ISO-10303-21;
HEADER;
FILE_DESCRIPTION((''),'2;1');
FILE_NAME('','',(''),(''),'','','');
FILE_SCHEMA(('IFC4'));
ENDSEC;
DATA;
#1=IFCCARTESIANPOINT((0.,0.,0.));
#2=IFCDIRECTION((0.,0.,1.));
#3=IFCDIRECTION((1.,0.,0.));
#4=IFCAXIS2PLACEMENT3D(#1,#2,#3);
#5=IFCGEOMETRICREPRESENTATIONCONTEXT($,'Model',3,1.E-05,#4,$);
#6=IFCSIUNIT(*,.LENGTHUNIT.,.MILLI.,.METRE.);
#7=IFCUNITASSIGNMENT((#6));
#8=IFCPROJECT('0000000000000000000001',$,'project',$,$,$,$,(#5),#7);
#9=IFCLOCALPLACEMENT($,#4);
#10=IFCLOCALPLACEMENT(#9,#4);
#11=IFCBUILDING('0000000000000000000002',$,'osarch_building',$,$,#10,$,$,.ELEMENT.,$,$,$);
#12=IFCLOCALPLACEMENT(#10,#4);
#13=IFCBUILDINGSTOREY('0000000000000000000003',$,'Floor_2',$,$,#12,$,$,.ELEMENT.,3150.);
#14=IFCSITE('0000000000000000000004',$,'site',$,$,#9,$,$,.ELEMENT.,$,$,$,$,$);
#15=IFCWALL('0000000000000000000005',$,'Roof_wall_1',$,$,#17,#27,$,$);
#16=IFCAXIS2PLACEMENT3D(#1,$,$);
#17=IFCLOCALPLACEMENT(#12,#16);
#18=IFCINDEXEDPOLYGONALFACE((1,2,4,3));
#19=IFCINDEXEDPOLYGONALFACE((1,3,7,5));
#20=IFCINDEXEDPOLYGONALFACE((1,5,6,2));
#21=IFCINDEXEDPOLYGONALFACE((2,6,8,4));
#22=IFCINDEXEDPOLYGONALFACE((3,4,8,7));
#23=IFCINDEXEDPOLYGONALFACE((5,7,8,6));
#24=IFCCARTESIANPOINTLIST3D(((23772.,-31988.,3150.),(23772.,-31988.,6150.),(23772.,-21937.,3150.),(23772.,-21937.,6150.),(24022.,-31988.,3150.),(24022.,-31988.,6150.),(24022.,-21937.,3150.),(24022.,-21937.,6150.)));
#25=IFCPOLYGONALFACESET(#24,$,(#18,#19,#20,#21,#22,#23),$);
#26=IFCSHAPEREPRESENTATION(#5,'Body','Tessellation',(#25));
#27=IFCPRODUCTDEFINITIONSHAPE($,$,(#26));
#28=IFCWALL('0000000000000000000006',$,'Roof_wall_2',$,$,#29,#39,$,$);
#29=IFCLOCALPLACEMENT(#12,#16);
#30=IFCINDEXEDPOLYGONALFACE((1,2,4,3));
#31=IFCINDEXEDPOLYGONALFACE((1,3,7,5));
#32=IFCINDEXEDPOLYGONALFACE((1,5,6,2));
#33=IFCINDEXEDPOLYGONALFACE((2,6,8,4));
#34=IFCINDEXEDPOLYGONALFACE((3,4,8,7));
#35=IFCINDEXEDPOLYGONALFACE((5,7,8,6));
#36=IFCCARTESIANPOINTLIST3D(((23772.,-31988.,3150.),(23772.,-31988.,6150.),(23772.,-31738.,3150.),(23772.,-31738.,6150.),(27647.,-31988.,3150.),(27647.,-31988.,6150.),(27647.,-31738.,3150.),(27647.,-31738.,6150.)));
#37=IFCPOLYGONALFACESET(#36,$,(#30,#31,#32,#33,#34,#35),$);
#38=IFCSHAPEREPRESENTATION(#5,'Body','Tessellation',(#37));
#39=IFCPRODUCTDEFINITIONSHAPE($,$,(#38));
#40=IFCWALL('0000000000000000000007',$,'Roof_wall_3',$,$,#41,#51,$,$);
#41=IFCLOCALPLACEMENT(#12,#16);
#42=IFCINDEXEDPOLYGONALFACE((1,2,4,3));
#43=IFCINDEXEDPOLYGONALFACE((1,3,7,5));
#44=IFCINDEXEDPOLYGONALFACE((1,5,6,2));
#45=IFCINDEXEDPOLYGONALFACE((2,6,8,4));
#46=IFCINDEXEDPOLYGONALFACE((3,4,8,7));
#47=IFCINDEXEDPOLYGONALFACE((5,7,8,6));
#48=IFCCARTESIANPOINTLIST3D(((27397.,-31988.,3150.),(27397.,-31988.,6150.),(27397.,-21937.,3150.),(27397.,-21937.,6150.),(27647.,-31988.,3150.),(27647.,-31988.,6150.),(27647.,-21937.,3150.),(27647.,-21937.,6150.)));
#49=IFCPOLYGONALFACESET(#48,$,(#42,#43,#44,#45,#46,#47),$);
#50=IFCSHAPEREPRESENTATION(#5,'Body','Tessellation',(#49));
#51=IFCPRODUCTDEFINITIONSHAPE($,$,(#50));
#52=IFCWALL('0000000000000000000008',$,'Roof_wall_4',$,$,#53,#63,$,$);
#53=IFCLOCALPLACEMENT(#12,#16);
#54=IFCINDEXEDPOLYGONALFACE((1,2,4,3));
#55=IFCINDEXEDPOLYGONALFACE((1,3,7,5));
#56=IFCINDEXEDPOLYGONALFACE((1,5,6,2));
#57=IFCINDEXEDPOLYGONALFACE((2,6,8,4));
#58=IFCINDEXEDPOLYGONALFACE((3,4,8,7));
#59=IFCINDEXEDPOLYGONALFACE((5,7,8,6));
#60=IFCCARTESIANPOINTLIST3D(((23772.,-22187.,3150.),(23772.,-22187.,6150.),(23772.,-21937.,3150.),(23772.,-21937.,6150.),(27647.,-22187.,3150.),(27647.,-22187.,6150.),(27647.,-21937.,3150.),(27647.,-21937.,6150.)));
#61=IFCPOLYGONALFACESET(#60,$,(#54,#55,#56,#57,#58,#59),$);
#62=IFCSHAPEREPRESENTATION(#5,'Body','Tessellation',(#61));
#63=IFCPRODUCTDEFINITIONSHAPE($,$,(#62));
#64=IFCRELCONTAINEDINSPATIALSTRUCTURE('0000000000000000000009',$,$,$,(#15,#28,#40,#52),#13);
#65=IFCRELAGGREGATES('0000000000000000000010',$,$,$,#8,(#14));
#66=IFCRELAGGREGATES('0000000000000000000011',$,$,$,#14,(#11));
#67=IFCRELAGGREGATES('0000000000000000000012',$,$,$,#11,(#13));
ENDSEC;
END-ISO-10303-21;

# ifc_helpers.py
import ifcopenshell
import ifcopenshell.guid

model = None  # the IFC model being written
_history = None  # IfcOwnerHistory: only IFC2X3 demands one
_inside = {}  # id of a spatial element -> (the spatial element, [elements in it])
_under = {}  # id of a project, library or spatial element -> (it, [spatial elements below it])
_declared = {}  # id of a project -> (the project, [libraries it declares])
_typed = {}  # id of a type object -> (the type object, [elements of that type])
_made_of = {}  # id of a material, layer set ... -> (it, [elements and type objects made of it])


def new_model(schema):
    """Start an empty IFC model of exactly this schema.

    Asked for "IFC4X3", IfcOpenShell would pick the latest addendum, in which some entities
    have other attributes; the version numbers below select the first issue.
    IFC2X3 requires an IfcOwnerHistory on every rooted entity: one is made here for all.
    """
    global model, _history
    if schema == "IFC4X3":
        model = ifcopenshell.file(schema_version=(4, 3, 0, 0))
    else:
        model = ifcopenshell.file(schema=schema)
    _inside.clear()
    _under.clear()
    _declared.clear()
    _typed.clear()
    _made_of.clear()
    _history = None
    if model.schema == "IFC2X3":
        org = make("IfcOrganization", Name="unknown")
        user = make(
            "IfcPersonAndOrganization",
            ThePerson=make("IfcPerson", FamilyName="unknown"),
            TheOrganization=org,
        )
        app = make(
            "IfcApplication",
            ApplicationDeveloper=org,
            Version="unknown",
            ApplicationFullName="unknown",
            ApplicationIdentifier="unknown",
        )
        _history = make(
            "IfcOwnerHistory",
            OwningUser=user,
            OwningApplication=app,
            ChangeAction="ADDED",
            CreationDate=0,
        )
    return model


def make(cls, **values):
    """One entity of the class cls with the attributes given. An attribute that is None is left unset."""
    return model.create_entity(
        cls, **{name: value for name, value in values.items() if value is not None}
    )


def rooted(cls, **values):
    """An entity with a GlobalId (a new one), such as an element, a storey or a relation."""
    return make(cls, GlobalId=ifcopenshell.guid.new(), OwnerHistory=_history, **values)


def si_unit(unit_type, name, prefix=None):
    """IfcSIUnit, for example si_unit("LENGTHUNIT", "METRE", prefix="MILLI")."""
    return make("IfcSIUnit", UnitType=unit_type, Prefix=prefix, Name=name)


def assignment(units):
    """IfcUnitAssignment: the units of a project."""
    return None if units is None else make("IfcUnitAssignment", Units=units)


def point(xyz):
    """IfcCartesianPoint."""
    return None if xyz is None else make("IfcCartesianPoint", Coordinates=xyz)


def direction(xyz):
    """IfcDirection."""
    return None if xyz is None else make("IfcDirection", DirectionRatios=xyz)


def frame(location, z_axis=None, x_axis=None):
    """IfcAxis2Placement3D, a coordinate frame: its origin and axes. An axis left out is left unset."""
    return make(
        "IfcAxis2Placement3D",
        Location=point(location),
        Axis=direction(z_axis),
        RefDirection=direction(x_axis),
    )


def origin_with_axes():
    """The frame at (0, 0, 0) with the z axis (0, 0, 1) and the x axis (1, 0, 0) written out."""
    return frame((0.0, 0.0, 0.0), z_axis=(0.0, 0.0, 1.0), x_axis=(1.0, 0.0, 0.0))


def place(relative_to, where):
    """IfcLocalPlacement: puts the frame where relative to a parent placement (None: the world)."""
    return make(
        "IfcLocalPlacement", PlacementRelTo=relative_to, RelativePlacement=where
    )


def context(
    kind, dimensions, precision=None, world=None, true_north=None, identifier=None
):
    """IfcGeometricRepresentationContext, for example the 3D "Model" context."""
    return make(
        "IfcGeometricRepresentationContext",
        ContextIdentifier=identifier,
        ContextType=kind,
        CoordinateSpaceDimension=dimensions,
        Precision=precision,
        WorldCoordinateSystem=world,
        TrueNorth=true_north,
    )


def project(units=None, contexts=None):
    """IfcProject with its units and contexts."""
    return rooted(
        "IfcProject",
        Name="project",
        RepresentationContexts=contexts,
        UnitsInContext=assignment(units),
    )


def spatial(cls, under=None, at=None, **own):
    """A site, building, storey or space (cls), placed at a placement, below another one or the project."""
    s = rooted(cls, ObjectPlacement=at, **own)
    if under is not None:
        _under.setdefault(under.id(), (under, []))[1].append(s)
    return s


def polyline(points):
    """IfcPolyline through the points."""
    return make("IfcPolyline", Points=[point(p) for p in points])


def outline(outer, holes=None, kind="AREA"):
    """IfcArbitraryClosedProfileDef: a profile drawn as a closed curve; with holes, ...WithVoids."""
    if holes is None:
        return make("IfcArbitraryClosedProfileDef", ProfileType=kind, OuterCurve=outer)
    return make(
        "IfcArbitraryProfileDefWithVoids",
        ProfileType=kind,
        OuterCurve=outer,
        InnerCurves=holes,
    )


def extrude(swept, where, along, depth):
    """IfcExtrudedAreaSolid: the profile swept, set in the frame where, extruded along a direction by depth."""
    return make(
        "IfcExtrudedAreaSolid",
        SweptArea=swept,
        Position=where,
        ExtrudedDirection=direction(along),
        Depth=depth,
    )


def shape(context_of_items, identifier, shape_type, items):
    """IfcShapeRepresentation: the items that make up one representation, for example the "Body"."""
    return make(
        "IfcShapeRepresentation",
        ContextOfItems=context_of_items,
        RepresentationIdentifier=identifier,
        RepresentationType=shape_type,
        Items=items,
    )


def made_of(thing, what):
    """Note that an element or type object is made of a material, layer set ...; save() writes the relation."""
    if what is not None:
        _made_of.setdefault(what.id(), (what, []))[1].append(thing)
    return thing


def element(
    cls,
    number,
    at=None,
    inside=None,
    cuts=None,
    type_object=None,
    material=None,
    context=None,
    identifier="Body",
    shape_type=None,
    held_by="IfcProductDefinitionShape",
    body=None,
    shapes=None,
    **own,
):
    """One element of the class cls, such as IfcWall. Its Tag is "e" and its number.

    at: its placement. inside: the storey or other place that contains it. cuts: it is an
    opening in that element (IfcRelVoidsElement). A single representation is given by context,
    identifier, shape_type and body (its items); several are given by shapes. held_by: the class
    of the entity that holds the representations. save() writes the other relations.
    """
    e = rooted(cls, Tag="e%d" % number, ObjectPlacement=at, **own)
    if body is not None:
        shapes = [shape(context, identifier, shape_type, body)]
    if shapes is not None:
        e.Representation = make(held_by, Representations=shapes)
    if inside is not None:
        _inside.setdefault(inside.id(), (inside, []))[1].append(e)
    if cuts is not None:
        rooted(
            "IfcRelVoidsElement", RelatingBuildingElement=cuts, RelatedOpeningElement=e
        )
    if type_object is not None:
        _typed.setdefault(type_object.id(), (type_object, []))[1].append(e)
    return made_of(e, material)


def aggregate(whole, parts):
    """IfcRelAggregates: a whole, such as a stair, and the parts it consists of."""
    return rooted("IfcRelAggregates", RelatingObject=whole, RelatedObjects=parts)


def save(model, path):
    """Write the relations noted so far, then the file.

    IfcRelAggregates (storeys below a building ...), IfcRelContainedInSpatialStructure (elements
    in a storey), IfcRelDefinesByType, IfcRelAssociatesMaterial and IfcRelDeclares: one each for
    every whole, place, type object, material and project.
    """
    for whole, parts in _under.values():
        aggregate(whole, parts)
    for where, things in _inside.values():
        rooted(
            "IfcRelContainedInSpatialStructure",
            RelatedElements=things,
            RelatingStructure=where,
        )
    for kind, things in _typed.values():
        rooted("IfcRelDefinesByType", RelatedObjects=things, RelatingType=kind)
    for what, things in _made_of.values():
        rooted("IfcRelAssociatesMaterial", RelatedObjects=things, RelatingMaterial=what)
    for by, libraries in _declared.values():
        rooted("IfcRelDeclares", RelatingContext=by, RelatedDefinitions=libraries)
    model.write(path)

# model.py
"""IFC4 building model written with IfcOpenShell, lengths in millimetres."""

from ifc_helpers import new_model, si_unit, frame, origin_with_axes, place, context, project, spatial, polyline, outline, extrude, element, save


model = new_model("IFC4")

# Units and contexts
model_context = context("Model", 3, precision=1e-05, world=origin_with_axes())
ifc_project = project(units=[si_unit("LENGTHUNIT", "METRE", prefix="MILLI")], contexts=[model_context])

# Site, building, storey
site_placement = place(None, origin_with_axes())
site = spatial("IfcSite", under=ifc_project, at=site_placement, Name="site", CompositionType="ELEMENT")
building_placement = place(site_placement, origin_with_axes())
building = spatial("IfcBuilding", under=site, at=building_placement, Name="osarch_building", CompositionType="ELEMENT")
storey_placement = place(building_placement, origin_with_axes())
storey = spatial("IfcBuildingStorey", under=building, at=storey_placement, Name="Floor_2", CompositionType="ELEMENT", Elevation=3150.0)

# Walls
element("IfcWall", 1, inside=storey, Name="Roof_wall_1", context=model_context, shape_type="SweptSolid", body=[
    extrude(outline(polyline([(23772.0, -21937.0, 0.0), (24022.0, -21937.0, 0.0), (24022.0, -31988.0, 0.0), (23772.0, -31988.0, 0.0), (23772.0, -21937.0, 0.0)])), frame((0.0, 0.0, 3150.0), z_axis=(0.0, 0.0, 1.0), x_axis=(1.0, 0.0, 0.0)), (0.0, 0.0, 1.0), 3000.0),
])
element("IfcWall", 2, inside=storey, Name="Roof_wall_2", context=model_context, shape_type="SweptSolid", body=[
    extrude(outline(polyline([(23772.0, -31988.0, 0.0), (23772.0, -31738.0, 0.0), (27647.0, -31738.0, 0.0), (27647.0, -31988.0, 0.0), (23772.0, -31988.0, 0.0)])), frame((0.0, 0.0, 3150.0), z_axis=(0.0, 0.0, 1.0), x_axis=(1.0, 0.0, 0.0)), (0.0, 0.0, 1.0), 3000.0),
])
element("IfcWall", 3, inside=storey, Name="Roof_wall_3", context=model_context, shape_type="SweptSolid", body=[
    extrude(outline(polyline([(27647.0, -31988.0, 0.0), (27397.0, -31988.0, 0.0), (27397.0, -21937.0, 0.0), (27647.0, -21937.0, 0.0), (27647.0, -31988.0, 0.0)])), frame((0.0, 0.0, 3150.0), z_axis=(0.0, 0.0, 1.0), x_axis=(1.0, 0.0, 0.0)), (0.0, 0.0, 1.0), 3000.0),
])
element("IfcWall", 4, inside=storey, Name="Roof_wall_4", context=model_context, shape_type="SweptSolid", body=[
    extrude(outline(polyline([(27647.0, -21937.0, 0.0), (27647.0, -22187.0, 0.0), (23772.0, -22187.0, 0.0), (23772.0, -21937.0, 0.0), (27647.0, -21937.0, 0.0)])), frame((0.0, 0.0, 3150.0), z_axis=(0.0, 0.0, 1.0), x_axis=(1.0, 0.0, 0.0)), (0.0, 0.0, 1.0), 3000.0),
])

save(model, "model.ifc")
